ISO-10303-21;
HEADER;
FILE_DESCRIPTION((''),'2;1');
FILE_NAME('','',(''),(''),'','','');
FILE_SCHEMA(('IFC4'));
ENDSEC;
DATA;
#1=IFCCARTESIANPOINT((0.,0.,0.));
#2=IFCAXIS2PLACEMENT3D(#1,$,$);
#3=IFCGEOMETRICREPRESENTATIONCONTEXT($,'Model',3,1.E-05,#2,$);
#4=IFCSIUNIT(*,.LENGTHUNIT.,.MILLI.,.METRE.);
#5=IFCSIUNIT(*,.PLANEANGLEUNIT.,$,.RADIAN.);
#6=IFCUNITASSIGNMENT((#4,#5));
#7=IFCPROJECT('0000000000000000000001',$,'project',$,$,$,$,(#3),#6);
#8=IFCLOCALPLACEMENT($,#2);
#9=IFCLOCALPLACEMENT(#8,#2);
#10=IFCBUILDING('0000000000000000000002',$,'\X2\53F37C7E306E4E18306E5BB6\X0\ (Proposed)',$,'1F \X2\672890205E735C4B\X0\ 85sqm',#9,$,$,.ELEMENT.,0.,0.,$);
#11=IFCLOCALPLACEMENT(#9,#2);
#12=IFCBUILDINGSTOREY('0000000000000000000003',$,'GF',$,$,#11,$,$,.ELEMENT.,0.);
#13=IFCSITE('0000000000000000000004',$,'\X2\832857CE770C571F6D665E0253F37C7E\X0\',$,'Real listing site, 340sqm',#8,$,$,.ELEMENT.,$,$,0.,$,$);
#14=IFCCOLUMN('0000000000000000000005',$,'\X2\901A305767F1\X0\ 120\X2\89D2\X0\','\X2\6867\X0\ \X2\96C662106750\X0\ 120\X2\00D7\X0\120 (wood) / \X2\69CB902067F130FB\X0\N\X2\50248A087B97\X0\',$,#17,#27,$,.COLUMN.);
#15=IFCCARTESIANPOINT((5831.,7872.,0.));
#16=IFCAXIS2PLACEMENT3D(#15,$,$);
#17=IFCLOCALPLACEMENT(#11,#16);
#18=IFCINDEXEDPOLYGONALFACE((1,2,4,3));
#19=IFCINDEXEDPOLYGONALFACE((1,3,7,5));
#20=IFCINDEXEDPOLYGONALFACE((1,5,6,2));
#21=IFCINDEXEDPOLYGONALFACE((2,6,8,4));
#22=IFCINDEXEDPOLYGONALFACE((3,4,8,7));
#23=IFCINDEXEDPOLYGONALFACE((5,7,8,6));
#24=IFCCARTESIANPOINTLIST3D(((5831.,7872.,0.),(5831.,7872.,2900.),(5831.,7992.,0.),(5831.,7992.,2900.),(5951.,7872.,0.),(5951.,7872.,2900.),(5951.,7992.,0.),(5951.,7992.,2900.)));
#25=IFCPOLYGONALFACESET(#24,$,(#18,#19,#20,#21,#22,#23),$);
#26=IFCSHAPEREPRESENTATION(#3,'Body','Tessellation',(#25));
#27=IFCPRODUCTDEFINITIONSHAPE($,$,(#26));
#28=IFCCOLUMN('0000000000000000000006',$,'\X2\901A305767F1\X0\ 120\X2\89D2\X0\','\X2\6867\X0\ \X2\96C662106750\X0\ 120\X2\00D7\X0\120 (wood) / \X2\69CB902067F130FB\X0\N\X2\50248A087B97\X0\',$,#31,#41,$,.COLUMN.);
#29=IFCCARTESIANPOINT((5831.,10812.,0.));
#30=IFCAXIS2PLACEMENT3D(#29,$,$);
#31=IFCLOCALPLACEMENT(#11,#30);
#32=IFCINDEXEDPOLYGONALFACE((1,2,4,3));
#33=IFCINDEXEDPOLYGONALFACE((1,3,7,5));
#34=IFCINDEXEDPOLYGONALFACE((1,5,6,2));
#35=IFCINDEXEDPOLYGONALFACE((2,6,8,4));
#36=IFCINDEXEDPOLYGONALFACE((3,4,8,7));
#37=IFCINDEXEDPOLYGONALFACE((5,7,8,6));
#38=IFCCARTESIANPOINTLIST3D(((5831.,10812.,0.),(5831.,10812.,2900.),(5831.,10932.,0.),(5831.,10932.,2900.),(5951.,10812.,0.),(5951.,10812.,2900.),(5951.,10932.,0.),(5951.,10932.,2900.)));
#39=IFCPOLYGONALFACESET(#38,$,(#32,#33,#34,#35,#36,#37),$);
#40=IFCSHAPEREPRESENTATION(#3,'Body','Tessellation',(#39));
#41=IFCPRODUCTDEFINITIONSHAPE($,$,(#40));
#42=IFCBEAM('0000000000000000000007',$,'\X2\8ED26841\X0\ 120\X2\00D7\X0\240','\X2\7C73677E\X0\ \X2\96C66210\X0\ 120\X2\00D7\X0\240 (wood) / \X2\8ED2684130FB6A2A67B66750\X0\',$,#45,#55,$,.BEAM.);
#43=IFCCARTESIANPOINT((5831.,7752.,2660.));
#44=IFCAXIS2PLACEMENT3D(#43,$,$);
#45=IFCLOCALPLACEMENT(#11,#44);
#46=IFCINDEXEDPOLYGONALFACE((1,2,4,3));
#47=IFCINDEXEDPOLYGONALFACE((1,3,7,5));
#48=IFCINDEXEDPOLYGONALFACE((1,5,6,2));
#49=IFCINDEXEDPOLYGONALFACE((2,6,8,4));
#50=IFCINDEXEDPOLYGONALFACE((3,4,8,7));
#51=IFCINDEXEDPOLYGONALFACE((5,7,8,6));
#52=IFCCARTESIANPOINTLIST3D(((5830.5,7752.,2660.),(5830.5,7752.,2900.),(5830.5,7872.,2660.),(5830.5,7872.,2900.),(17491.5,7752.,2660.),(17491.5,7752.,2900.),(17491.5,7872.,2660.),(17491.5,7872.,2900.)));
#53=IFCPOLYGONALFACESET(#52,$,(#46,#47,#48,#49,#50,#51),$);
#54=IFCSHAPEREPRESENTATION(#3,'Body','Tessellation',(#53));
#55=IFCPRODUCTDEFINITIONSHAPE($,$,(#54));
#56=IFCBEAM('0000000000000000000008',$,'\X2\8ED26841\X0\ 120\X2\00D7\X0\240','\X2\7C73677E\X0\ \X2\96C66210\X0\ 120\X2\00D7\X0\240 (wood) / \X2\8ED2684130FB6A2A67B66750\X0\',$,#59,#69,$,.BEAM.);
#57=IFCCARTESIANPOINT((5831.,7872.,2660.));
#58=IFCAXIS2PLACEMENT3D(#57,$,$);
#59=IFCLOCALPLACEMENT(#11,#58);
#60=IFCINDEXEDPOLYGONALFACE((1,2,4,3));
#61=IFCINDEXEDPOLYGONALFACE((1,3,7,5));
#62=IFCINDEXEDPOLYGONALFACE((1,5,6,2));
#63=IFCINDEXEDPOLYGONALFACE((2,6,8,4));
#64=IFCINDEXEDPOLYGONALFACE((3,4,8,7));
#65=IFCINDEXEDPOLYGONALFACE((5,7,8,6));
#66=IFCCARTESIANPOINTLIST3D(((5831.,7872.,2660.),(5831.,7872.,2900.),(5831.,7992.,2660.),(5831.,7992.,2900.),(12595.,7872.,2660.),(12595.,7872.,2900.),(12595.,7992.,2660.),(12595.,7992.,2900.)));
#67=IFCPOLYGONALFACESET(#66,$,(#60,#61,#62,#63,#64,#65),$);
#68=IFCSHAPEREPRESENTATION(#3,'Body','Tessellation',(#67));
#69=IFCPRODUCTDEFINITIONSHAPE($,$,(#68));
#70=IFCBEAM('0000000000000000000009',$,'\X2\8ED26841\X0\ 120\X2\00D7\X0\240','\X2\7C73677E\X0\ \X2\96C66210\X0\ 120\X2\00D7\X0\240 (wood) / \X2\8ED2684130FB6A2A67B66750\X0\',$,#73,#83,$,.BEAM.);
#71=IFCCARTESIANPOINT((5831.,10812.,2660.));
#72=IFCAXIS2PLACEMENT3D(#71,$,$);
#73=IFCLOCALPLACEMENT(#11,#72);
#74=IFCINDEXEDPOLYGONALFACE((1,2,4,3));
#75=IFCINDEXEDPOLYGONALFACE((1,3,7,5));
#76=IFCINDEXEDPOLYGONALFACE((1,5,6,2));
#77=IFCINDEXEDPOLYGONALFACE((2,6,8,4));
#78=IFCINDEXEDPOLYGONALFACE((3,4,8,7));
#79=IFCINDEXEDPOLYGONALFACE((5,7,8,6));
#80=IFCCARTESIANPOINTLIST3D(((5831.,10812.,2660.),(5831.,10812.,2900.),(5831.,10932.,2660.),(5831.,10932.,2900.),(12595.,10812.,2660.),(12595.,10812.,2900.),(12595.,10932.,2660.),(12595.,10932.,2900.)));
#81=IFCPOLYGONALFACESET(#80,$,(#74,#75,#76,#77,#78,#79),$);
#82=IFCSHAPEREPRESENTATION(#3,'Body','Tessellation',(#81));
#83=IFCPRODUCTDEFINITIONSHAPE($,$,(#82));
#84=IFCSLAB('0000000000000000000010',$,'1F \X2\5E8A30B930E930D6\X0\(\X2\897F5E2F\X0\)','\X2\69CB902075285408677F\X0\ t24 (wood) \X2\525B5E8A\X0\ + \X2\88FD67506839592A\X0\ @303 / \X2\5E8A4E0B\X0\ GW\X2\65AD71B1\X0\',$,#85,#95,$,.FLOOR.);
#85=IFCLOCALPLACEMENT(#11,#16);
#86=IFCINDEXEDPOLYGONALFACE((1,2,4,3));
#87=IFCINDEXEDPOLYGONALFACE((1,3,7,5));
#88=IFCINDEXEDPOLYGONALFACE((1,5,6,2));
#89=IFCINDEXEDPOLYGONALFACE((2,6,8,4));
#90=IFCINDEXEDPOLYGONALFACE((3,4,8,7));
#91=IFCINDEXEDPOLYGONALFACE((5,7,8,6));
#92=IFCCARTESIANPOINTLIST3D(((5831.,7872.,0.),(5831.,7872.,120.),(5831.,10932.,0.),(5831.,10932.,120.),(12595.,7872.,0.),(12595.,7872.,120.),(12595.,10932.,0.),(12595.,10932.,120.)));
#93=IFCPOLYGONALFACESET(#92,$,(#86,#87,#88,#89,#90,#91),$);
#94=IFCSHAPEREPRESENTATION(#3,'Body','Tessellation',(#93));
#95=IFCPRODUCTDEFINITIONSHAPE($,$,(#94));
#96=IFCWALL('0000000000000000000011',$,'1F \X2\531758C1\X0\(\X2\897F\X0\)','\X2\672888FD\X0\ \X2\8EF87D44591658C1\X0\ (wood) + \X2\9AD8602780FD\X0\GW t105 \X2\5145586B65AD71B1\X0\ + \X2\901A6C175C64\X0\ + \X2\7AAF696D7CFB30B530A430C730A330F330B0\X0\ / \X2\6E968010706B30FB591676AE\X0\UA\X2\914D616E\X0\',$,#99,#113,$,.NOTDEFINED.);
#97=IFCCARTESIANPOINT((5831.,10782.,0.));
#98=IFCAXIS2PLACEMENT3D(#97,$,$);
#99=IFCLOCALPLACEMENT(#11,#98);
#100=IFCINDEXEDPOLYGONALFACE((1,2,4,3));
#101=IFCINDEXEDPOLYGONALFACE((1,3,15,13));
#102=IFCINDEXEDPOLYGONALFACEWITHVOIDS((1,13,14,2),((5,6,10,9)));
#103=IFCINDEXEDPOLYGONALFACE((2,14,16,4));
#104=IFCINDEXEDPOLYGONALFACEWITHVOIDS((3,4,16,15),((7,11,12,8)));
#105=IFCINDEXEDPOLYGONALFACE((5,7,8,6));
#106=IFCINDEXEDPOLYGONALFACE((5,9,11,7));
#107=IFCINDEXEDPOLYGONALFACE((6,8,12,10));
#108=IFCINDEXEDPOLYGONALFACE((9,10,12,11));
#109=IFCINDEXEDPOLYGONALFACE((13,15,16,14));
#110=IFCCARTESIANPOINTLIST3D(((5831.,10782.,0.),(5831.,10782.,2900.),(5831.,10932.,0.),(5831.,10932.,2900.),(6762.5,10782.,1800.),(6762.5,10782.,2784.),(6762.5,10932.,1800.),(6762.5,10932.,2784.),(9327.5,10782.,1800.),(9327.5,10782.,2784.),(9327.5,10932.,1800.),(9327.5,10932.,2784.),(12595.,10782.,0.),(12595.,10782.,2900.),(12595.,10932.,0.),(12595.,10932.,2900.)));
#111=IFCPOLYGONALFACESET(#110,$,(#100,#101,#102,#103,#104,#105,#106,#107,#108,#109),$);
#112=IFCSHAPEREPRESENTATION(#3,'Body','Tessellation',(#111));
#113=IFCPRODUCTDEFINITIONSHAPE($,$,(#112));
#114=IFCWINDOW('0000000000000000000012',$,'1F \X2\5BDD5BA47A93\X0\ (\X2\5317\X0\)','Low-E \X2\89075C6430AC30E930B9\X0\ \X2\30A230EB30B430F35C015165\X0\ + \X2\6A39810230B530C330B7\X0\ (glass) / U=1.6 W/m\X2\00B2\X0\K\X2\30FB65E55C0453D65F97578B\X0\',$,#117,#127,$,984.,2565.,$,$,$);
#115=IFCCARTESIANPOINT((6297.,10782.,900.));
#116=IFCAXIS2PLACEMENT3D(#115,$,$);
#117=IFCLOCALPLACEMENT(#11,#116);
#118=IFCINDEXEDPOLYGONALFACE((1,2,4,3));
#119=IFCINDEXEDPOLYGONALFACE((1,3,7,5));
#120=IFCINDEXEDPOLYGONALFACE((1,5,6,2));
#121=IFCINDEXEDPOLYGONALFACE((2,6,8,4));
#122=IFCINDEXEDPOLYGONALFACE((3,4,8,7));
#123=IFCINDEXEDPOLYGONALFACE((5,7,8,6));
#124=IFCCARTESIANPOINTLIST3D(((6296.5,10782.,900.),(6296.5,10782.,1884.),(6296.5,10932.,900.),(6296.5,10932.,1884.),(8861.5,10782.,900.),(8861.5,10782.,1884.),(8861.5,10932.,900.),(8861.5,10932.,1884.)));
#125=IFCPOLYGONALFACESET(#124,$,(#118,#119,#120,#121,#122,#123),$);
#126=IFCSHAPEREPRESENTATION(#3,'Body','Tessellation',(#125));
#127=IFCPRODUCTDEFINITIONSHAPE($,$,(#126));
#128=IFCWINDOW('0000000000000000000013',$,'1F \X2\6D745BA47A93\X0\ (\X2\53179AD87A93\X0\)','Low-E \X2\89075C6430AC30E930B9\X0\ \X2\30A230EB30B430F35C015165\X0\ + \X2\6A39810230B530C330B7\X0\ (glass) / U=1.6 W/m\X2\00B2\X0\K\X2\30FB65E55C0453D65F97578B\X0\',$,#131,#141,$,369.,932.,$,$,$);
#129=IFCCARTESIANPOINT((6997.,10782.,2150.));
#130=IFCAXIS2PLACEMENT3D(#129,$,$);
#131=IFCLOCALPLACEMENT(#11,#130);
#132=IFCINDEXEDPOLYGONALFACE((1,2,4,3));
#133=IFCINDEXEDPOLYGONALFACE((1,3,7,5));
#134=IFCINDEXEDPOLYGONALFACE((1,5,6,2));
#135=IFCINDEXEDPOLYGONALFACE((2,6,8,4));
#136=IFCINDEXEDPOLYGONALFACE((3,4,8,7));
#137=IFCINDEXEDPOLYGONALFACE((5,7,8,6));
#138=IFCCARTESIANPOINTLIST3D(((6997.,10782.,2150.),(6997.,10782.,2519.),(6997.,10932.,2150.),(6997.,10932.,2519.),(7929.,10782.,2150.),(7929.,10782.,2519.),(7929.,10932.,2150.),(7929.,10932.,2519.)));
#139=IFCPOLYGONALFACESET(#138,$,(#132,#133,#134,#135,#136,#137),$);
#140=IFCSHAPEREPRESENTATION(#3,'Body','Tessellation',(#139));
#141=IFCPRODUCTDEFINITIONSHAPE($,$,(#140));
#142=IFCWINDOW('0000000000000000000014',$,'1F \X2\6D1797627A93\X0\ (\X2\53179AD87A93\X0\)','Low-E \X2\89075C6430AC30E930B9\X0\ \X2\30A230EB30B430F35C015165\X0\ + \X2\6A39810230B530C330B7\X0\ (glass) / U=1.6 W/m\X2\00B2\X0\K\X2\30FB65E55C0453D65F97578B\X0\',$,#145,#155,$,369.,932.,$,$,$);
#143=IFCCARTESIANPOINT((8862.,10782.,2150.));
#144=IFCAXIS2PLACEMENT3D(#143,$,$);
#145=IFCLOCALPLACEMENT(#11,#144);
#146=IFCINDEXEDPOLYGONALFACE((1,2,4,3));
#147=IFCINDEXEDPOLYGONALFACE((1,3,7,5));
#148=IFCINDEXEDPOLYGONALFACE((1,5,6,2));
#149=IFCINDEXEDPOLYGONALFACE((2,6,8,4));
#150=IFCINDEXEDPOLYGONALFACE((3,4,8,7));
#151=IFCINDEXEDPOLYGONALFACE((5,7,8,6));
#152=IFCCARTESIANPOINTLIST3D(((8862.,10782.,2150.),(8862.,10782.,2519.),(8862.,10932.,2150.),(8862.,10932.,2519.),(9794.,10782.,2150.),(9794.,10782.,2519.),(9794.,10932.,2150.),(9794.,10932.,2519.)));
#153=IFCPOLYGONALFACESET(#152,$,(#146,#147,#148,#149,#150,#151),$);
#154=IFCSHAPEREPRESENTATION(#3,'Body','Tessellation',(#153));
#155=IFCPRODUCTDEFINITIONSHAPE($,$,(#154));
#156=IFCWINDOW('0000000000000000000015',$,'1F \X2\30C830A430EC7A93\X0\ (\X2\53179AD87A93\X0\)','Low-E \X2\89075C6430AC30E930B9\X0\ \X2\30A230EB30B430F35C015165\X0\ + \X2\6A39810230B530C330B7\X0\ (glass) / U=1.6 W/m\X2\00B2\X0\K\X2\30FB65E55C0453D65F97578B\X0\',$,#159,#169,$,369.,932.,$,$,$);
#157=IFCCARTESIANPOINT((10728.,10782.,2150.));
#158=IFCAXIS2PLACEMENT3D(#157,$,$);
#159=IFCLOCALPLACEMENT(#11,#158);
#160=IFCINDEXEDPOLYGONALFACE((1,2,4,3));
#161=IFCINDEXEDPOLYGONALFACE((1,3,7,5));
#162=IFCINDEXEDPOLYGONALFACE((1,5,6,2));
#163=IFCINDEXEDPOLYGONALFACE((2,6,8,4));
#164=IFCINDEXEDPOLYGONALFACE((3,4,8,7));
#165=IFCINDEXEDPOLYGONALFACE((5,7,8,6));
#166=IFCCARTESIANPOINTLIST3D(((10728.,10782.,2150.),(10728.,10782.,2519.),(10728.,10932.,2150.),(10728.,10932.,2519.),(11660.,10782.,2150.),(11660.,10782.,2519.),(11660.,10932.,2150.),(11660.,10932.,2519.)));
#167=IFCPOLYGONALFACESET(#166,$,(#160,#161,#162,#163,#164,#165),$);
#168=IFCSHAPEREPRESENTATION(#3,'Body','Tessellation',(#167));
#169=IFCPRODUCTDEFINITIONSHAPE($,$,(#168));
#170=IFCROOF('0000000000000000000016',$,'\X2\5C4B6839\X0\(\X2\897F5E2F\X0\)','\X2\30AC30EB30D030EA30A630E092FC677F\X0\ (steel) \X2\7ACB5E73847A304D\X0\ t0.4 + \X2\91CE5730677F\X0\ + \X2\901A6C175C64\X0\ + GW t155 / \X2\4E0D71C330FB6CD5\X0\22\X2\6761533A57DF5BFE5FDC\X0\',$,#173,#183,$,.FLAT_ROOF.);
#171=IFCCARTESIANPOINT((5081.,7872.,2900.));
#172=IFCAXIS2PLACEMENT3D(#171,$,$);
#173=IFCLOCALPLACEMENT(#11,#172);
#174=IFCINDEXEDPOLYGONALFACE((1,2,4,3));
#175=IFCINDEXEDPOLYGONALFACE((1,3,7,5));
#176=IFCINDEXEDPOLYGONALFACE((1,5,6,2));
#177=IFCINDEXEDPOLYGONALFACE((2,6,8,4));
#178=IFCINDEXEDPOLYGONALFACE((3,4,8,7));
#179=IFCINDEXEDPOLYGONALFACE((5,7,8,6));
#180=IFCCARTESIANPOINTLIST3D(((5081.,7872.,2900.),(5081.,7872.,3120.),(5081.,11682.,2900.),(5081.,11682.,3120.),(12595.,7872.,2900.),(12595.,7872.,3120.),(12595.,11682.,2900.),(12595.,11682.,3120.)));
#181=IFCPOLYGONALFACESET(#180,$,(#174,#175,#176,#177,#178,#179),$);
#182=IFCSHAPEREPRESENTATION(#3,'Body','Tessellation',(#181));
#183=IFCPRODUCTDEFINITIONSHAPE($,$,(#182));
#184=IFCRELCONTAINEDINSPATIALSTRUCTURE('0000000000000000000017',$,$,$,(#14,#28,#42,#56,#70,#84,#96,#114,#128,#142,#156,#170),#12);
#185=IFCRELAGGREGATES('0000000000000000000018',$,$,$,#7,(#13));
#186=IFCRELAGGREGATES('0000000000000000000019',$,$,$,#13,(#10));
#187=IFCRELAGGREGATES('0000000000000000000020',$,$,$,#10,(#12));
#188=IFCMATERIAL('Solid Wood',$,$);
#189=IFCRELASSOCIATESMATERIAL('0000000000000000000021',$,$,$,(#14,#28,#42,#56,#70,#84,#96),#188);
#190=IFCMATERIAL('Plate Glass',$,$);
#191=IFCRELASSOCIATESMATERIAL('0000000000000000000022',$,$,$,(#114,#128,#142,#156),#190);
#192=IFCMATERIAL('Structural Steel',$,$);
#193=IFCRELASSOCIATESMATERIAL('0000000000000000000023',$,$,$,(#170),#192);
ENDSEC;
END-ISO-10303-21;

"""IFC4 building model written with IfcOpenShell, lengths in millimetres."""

from ifc_helpers import new_model, si_unit, frame, frame_2d, origin, place, context, project, spatial, rectangle, extrude, material, element, fill, save


model = new_model("IFC4")

# Units and contexts
model_context = context("Model", 3, precision=1e-05, world=origin())
ifc_project = project(units=[si_unit("LENGTHUNIT", "METRE", prefix="MILLI"), si_unit("PLANEANGLEUNIT", "RADIAN")], contexts=[model_context])

# Site, building, storey
site_placement = place(None, origin())
site = spatial("IfcSite", under=ifc_project, at=site_placement, Name="茨城県土浦市右籾", ObjectType="Real listing site, 340sqm", CompositionType="ELEMENT", RefElevation=0.0)
building_placement = place(site_placement, origin())
building = spatial("IfcBuilding", under=site, at=building_placement, Name="右籾の丘の家 (Proposed)", ObjectType="1F 木造平屋 85sqm", CompositionType="ELEMENT", ElevationOfRefHeight=0.0, ElevationOfTerrain=0.0)
storey_placement = place(building_placement, origin())
storey = spatial("IfcBuildingStorey", under=building, at=storey_placement, Name="GF", CompositionType="ELEMENT", Elevation=0.0)

# Columns
ifc_material_1 = material(Name="Solid Wood")
column_1_placement = place(storey_placement, frame((5831.0, 7872.0, 0.0)))
element("IfcColumn", 1, at=column_1_placement, inside=storey, material=ifc_material_1, Name="通し柱 120角", Description="桧 集成材 120×120 (wood) / 構造柱・N値計算", PredefinedType="COLUMN", context=model_context, shape_type="SweptSolid", body=[
    extrude(rectangle(XDim=120.0, YDim=120.0, at=frame_2d((60.0, 60.0))), frame((5831.0, 7872.0, 0.0)), (0.0, 0.0, 1.0), 2900.0),
])
column_2_placement = place(storey_placement, frame((5831.0, 10812.0, 0.0)))
element("IfcColumn", 2, at=column_2_placement, inside=storey, material=ifc_material_1, Name="通し柱 120角", Description="桧 集成材 120×120 (wood) / 構造柱・N値計算", PredefinedType="COLUMN", context=model_context, shape_type="SweptSolid", body=[
    extrude(rectangle(XDim=120.0, YDim=120.0, at=frame_2d((60.0, 60.0))), frame((5831.0, 10812.0, 0.0)), (0.0, 0.0, 1.0), 2900.0),
])

# Beams
beam_1_placement = place(storey_placement, frame((5831.0, 7752.0, 2660.0)))
element("IfcBeam", 3, at=beam_1_placement, inside=storey, material=ifc_material_1, Name="軒桁 120×240", Description="米松 集成 120×240 (wood) / 軒桁・横架材", PredefinedType="BEAM", context=model_context, shape_type="SweptSolid", body=[
    extrude(rectangle(XDim=11661.0, YDim=120.0, at=frame_2d((5830.0, 60.0))), frame((5831.0, 7752.0, 2660.0)), (0.0, 0.0, 1.0), 240.0),
])
beam_2_placement = place(storey_placement, frame((5831.0, 7872.0, 2660.0)))
element("IfcBeam", 4, at=beam_2_placement, inside=storey, material=ifc_material_1, Name="軒桁 120×240", Description="米松 集成 120×240 (wood) / 軒桁・横架材", PredefinedType="BEAM", context=model_context, shape_type="SweptSolid", body=[
    extrude(rectangle(XDim=6764.0, YDim=120.0, at=frame_2d((3382.0, 60.0))), frame((5831.0, 7872.0, 2660.0)), (0.0, 0.0, 1.0), 240.0),
])
beam_3_placement = place(storey_placement, frame((5831.0, 10812.0, 2660.0)))
element("IfcBeam", 5, at=beam_3_placement, inside=storey, material=ifc_material_1, Name="軒桁 120×240", Description="米松 集成 120×240 (wood) / 軒桁・横架材", PredefinedType="BEAM", context=model_context, shape_type="SweptSolid", body=[
    extrude(rectangle(XDim=6764.0, YDim=120.0, at=frame_2d((3382.0, 60.0))), frame((5831.0, 10812.0, 2660.0)), (0.0, 0.0, 1.0), 240.0),
])

# Slab
slab_placement = place(storey_placement, frame((5831.0, 7872.0, 0.0)))
element("IfcSlab", 6, at=slab_placement, inside=storey, material=ifc_material_1, Name="1F 床スラブ(西帯)", Description="構造用合板 t24 (wood) 剛床 + 製材根太 @303 / 床下 GW断熱", PredefinedType="FLOOR", context=model_context, shape_type="SweptSolid", body=[
    extrude(rectangle(XDim=6764.0, YDim=3060.0, at=frame_2d((3382.0, 1530.0))), frame((5831.0, 7872.0, 0.0)), (0.0, 0.0, 1.0), 120.0),
])

# Wall, openings, windows
wall_1_placement = place(storey_placement, frame((5831.0, 10782.0, 0.0)))
wall_1 = element("IfcWall", 7, at=wall_1_placement, inside=storey, material=ifc_material_1, Name="1F 北壁(西)", Description="木製 軸組外壁 (wood) + 高性能GW t105 充填断熱 + 通気層 + 窯業系サイディング / 準耐火・外皮UA配慮", PredefinedType="NOTDEFINED", context=model_context, shape_type="SweptSolid", body=[
    extrude(rectangle(XDim=6764.0, YDim=150.0, at=frame_2d((3382.0, 75.0))), frame((5831.0, 10782.0, 0.0)), (0.0, 0.0, 1.0), 2900.0),
])
opening_1_placement = place(storey_placement, frame((6297.0, 10782.0, 900.0)))
opening_1 = element("IfcOpeningElement", 8, at=opening_1_placement, cuts=wall_1, PredefinedType="NOTDEFINED", context=model_context, shape_type="SweptSolid", body=[
    extrude(rectangle(XDim=2565.0, YDim=150.0, at=frame_2d((1282.0, 75.0))), frame((6297.0, 10782.0, 900.0)), (0.0, 0.0, 1.0), 984.0),
])
opening_2_placement = place(storey_placement, frame((6997.0, 10782.0, 2150.0)))
opening_2 = element("IfcOpeningElement", 9, at=opening_2_placement, cuts=wall_1, PredefinedType="NOTDEFINED", context=model_context, shape_type="SweptSolid", body=[
    extrude(rectangle(XDim=932.0, YDim=150.0, at=frame_2d((466.0, 75.0))), frame((6997.0, 10782.0, 2150.0)), (0.0, 0.0, 1.0), 369.0),
])
opening_3_placement = place(storey_placement, frame((8862.0, 10782.0, 2150.0)))
opening_3 = element("IfcOpeningElement", 10, at=opening_3_placement, cuts=wall_1, PredefinedType="NOTDEFINED", context=model_context, shape_type="SweptSolid", body=[
    extrude(rectangle(XDim=932.0, YDim=150.0, at=frame_2d((466.0, 75.0))), frame((8862.0, 10782.0, 2150.0)), (0.0, 0.0, 1.0), 369.0),
])
opening_4_placement = place(storey_placement, frame((10728.0, 10782.0, 2150.0)))
opening_4 = element("IfcOpeningElement", 11, at=opening_4_placement, cuts=wall_1, PredefinedType="NOTDEFINED", context=model_context, shape_type="SweptSolid", body=[
    extrude(rectangle(XDim=932.0, YDim=150.0, at=frame_2d((466.0, 75.0))), frame((10728.0, 10782.0, 2150.0)), (0.0, 0.0, 1.0), 369.0),
])
ifc_material_2 = material(Name="Plate Glass")
window_1_placement = place(storey_placement, frame((6297.0, 10782.0, 900.0)))
window_1 = element("IfcWindow", 12, at=window_1_placement, inside=storey, material=ifc_material_2, Name="1F 寝室窓 (北)", Description="Low-E 複層ガラス アルゴン封入 + 樹脂サッシ (glass) / U=1.6 W/m²K・日射取得型", OverallHeight=984.0, OverallWidth=2565.0, context=model_context, shape_type="SweptSolid", body=[
    extrude(rectangle(XDim=2565.0, YDim=150.0, at=frame_2d((1282.0, 75.0))), frame((6297.0, 10782.0, 900.0)), (0.0, 0.0, 1.0), 984.0),
])
fill(opening_1, window_1)
window_2_placement = place(storey_placement, frame((6997.0, 10782.0, 2150.0)))
window_2 = element("IfcWindow", 13, at=window_2_placement, inside=storey, material=ifc_material_2, Name="1F 浴室窓 (北高窓)", Description="Low-E 複層ガラス アルゴン封入 + 樹脂サッシ (glass) / U=1.6 W/m²K・日射取得型", OverallHeight=369.0, OverallWidth=932.0, context=model_context, shape_type="SweptSolid", body=[
    extrude(rectangle(XDim=932.0, YDim=150.0, at=frame_2d((466.0, 75.0))), frame((6997.0, 10782.0, 2150.0)), (0.0, 0.0, 1.0), 369.0),
])
fill(opening_2, window_2)
window_3_placement = place(storey_placement, frame((8862.0, 10782.0, 2150.0)))
window_3 = element("IfcWindow", 14, at=window_3_placement, inside=storey, material=ifc_material_2, Name="1F 洗面窓 (北高窓)", Description="Low-E 複層ガラス アルゴン封入 + 樹脂サッシ (glass) / U=1.6 W/m²K・日射取得型", OverallHeight=369.0, OverallWidth=932.0, context=model_context, shape_type="SweptSolid", body=[
    extrude(rectangle(XDim=932.0, YDim=150.0, at=frame_2d((466.0, 75.0))), frame((8862.0, 10782.0, 2150.0)), (0.0, 0.0, 1.0), 369.0),
])
fill(opening_3, window_3)
window_4_placement = place(storey_placement, frame((10728.0, 10782.0, 2150.0)))
window_4 = element("IfcWindow", 15, at=window_4_placement, inside=storey, material=ifc_material_2, Name="1F トイレ窓 (北高窓)", Description="Low-E 複層ガラス アルゴン封入 + 樹脂サッシ (glass) / U=1.6 W/m²K・日射取得型", OverallHeight=369.0, OverallWidth=932.0, context=model_context, shape_type="SweptSolid", body=[
    extrude(rectangle(XDim=932.0, YDim=150.0, at=frame_2d((466.0, 75.0))), frame((10728.0, 10782.0, 2150.0)), (0.0, 0.0, 1.0), 369.0),
])
fill(opening_4, window_4)

# Roof
ifc_material_3 = material(Name="Structural Steel")
roof_placement = place(storey_placement, frame((5081.0, 7872.0, 2900.0)))
element("IfcRoof", 16, at=roof_placement, inside=storey, material=ifc_material_3, Name="屋根(西帯)", Description="ガルバリウム鋼板 (steel) 立平葺き t0.4 + 野地板 + 通気層 + GW t155 / 不燃・法22条区域対応", PredefinedType="FLAT_ROOF", context=model_context, shape_type="SweptSolid", body=[
    extrude(rectangle(XDim=7514.0, YDim=3810.0, at=frame_2d((3757.0, 1905.0))), frame((5081.0, 7872.0, 2900.0)), (0.0, 0.0, 1.0), 220.0),
])

save(model, "model.ifc")
